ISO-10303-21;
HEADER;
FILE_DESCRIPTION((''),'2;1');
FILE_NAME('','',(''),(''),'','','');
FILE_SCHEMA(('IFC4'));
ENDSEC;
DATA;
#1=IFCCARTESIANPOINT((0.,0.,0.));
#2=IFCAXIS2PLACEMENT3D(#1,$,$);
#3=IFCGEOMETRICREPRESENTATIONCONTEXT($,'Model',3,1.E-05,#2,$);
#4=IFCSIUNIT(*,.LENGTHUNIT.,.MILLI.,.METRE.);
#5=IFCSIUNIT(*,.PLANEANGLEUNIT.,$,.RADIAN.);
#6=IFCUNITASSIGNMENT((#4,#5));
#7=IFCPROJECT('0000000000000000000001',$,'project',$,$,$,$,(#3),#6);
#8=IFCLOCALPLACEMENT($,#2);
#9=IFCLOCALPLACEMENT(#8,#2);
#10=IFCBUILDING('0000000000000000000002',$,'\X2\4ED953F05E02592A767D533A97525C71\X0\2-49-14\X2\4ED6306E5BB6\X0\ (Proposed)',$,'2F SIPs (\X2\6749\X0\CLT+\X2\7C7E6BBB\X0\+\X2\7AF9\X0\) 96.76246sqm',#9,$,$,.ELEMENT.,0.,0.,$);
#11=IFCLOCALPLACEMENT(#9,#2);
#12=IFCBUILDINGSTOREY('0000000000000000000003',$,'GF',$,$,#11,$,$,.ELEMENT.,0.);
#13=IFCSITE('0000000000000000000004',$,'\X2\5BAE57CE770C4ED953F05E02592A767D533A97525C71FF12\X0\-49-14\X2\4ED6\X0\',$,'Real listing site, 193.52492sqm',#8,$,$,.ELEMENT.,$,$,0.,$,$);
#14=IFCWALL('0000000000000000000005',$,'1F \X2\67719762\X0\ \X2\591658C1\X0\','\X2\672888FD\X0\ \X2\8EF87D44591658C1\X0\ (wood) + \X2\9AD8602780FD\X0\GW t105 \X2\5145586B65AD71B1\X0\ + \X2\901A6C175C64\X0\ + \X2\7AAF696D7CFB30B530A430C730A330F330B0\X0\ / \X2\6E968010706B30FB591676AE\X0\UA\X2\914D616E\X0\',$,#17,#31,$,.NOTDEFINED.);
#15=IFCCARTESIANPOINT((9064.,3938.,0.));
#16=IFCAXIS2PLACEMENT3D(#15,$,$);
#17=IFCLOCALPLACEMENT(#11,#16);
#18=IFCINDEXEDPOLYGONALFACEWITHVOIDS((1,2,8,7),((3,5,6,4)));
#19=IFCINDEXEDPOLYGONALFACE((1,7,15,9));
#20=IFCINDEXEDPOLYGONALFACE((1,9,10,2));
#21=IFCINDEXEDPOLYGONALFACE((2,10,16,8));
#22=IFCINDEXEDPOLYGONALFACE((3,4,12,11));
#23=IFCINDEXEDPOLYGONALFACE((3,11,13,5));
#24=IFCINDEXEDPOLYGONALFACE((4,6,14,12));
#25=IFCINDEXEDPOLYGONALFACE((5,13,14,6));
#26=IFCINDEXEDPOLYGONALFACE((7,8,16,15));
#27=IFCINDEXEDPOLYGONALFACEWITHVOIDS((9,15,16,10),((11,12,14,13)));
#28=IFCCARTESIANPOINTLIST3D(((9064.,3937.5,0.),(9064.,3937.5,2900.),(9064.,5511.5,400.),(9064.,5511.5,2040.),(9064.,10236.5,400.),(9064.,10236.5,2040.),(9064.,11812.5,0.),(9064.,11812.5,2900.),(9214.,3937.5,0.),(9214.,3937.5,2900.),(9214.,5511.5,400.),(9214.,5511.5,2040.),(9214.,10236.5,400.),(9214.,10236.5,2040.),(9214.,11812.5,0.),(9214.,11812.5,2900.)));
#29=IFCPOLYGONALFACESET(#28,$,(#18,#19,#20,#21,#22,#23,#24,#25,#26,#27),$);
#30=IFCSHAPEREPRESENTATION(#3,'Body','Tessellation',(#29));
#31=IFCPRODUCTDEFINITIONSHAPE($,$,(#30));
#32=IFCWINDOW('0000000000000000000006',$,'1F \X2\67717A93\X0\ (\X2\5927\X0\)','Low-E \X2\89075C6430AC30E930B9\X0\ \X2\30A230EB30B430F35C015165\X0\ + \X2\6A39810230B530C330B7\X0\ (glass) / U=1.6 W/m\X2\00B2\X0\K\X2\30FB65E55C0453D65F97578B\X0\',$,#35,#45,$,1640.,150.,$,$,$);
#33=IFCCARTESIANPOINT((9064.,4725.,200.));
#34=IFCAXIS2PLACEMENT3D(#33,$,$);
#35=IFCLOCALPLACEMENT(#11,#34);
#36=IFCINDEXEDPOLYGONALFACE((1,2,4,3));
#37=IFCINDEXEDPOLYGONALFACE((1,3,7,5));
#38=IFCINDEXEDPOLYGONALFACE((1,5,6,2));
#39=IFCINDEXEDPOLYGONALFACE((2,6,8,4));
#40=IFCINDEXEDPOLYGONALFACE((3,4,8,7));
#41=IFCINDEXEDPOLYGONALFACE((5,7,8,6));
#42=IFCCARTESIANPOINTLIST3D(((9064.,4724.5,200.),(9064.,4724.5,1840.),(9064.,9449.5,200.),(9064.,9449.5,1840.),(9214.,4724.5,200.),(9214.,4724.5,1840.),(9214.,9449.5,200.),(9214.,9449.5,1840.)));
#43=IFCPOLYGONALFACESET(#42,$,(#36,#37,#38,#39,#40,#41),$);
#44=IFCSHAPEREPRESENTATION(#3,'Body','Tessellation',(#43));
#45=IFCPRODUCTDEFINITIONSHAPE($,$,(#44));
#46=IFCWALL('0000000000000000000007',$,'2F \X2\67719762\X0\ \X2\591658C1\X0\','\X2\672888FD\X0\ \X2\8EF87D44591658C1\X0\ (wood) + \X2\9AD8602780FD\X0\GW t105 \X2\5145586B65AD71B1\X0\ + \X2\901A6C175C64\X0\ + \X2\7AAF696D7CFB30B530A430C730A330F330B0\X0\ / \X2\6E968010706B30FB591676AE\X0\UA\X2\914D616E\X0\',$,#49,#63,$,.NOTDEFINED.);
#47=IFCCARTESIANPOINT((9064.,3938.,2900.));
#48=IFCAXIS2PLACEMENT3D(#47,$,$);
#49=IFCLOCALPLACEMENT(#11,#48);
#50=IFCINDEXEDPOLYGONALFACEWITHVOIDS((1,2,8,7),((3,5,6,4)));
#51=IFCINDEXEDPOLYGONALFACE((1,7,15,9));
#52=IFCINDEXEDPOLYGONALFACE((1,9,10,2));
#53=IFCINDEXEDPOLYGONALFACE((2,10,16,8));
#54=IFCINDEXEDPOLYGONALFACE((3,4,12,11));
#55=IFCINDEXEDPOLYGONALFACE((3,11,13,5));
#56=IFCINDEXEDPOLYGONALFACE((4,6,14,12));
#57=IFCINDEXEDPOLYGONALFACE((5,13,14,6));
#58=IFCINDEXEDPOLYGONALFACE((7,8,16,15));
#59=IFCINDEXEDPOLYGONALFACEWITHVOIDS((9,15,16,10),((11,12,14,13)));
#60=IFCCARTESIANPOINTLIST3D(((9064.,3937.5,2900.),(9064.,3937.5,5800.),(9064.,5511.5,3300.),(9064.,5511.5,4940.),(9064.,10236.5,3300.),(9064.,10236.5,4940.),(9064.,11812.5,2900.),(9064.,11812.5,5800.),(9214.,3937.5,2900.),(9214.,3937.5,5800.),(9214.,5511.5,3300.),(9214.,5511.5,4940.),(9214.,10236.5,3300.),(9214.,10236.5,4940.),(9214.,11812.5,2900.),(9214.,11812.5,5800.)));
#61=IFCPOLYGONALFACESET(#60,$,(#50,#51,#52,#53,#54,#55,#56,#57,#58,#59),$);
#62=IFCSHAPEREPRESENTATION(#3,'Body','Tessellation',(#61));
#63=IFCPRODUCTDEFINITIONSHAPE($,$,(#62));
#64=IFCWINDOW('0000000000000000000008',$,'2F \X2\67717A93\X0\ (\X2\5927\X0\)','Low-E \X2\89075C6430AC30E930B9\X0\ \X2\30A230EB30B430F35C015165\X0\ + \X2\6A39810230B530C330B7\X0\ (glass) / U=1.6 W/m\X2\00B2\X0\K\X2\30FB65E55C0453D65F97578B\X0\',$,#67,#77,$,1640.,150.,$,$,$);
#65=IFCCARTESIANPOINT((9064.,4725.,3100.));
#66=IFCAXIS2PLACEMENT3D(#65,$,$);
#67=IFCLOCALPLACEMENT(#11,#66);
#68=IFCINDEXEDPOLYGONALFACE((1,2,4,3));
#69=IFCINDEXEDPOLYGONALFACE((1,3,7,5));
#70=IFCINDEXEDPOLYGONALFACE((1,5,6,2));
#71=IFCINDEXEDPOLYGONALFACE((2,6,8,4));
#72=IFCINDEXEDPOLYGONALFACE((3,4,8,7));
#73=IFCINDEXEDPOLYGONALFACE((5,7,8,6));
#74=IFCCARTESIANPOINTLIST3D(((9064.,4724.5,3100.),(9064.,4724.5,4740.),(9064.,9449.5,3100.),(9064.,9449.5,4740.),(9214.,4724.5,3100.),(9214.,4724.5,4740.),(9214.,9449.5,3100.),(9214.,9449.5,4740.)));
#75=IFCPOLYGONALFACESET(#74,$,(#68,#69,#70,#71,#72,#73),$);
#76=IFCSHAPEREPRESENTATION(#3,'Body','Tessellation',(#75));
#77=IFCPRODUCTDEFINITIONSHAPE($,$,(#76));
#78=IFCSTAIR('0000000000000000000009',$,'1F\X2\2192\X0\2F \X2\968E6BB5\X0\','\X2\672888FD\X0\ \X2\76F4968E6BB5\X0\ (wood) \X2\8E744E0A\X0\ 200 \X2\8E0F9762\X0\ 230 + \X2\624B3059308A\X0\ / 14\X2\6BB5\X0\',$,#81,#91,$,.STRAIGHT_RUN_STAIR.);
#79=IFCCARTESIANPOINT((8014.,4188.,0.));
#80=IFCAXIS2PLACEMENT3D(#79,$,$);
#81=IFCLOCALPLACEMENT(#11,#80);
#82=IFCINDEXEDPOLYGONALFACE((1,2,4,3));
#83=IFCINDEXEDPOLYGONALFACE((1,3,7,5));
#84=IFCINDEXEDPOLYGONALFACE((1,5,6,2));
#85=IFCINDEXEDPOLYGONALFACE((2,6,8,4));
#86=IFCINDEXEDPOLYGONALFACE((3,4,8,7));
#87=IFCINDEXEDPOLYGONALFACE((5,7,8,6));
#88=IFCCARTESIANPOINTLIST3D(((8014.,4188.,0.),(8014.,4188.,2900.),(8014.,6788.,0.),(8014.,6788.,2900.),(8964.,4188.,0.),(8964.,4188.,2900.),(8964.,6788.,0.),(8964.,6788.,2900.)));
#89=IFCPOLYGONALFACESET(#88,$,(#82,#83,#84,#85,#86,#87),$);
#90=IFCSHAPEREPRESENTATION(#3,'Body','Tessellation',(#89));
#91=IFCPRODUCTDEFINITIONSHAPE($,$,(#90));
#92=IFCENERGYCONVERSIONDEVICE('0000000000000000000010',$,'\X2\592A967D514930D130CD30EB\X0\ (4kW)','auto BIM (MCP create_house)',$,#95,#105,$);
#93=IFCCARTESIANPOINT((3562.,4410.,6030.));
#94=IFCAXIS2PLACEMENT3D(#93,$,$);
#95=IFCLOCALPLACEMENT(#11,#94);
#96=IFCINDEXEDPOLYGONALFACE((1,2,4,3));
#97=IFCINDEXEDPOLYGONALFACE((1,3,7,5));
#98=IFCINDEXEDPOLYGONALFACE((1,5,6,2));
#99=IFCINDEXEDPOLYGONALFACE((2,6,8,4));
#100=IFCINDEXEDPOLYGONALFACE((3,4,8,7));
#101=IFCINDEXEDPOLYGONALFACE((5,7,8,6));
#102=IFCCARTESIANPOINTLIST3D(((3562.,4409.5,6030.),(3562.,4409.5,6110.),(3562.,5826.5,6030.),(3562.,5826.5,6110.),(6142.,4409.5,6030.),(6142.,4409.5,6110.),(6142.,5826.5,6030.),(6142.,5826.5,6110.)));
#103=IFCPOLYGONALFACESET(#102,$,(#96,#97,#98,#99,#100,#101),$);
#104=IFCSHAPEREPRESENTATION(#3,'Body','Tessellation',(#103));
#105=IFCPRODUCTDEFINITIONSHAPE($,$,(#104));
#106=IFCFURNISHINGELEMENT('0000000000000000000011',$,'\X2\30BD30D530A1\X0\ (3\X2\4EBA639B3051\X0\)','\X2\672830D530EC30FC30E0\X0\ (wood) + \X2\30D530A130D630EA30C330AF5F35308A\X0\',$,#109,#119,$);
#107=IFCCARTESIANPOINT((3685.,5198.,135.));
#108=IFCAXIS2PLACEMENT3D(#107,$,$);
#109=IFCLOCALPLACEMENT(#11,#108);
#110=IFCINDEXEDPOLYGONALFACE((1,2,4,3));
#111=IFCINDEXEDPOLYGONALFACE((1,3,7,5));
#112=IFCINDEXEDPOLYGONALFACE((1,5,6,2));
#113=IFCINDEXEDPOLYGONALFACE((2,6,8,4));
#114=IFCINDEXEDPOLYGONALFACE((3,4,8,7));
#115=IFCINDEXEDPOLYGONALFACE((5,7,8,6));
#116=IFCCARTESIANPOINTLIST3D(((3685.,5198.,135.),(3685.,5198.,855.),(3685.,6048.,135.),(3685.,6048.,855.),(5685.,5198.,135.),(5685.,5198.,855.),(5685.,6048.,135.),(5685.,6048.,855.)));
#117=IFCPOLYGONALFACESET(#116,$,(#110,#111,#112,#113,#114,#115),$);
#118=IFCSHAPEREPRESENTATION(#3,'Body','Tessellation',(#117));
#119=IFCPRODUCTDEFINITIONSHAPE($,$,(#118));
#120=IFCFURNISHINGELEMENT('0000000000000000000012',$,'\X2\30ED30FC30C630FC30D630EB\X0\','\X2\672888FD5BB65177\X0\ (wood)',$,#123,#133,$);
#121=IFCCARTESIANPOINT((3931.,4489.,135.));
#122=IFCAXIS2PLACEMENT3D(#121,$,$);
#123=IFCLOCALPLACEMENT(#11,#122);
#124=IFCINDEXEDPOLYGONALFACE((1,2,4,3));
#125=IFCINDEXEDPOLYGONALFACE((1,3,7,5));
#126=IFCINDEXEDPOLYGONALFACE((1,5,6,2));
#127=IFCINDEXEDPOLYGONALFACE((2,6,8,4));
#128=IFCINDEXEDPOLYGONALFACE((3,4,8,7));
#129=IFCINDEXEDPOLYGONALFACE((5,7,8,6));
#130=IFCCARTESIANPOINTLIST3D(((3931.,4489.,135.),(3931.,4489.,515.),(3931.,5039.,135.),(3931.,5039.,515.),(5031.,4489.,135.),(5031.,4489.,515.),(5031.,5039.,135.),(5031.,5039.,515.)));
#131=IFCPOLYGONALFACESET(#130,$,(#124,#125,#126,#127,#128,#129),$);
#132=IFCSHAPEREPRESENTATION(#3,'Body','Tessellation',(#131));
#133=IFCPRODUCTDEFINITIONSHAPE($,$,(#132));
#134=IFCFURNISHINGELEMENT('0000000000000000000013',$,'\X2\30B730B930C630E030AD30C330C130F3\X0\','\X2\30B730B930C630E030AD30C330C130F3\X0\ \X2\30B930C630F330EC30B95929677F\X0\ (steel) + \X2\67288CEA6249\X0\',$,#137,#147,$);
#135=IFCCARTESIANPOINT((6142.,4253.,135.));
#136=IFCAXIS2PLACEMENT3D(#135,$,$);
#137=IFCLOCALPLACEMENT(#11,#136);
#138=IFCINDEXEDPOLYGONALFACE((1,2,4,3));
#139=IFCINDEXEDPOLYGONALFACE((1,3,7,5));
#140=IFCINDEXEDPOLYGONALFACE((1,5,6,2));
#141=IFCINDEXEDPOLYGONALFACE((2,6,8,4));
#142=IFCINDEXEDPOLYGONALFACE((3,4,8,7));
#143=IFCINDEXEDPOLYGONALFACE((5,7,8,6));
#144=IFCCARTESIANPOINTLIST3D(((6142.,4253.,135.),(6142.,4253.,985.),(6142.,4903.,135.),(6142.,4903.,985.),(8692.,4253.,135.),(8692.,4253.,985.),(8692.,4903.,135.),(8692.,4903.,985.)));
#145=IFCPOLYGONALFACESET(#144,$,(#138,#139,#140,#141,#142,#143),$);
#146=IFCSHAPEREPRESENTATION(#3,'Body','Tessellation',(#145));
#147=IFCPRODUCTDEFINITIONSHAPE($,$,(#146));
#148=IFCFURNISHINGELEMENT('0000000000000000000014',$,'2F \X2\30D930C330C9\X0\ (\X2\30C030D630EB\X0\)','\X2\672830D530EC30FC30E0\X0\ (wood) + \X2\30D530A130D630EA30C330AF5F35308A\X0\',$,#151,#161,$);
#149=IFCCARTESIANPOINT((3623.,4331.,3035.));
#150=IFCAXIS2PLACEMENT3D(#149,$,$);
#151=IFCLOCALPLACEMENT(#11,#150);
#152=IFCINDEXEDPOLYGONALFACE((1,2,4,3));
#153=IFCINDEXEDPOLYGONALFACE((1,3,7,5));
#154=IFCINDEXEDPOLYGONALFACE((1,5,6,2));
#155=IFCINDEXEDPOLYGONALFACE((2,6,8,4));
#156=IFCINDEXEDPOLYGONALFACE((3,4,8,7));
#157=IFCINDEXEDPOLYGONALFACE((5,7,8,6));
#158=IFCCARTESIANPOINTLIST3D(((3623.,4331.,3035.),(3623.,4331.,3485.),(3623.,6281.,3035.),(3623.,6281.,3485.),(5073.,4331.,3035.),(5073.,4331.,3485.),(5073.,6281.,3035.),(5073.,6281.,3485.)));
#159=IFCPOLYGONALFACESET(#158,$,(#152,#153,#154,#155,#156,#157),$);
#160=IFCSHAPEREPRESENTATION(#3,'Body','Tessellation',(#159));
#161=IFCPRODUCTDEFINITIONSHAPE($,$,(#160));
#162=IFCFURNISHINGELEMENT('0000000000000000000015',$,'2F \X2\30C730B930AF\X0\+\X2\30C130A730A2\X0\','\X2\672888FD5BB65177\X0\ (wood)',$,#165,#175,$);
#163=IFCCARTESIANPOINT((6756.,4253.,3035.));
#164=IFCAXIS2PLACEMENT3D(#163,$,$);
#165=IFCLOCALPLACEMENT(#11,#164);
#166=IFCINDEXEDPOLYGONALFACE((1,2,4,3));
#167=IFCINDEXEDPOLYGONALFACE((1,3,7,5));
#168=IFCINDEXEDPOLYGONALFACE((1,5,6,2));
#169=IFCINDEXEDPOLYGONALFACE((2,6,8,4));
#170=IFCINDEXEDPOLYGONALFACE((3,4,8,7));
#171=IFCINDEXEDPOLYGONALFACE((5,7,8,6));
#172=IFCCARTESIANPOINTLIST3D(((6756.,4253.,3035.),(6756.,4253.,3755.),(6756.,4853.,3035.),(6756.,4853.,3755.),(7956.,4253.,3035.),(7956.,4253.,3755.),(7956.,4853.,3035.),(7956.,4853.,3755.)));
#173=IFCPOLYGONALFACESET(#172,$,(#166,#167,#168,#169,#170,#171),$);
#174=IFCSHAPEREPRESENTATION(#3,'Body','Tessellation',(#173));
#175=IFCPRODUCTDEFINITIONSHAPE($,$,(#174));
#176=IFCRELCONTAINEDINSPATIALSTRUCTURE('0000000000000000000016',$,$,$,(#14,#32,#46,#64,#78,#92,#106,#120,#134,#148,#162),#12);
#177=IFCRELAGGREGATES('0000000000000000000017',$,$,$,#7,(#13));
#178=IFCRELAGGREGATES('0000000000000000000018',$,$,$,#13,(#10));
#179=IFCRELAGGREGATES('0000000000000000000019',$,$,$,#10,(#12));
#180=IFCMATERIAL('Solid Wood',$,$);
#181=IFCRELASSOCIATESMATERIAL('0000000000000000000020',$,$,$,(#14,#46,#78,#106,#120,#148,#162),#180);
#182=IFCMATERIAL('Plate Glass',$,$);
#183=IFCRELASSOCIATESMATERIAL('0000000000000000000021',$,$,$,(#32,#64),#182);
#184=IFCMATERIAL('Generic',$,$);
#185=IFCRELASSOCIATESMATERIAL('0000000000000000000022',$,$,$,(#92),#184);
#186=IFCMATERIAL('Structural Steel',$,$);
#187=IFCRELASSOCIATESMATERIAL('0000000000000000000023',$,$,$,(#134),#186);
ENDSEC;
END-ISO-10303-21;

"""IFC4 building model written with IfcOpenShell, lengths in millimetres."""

from ifc_helpers import new_model, si_unit, frame, frame_2d, origin, place, context, project, spatial, rectangle, extrude, material, element, fill, save


model = new_model("IFC4")

# Units and contexts
model_context = context("Model", 3, precision=1e-05, world=origin())
ifc_project = project(units=[si_unit("LENGTHUNIT", "METRE", prefix="MILLI"), si_unit("PLANEANGLEUNIT", "RADIAN")], contexts=[model_context])

# Site, building, storey
site_placement = place(None, origin())
site = spatial("IfcSite", under=ifc_project, at=site_placement, Name="宮城県仙台市太白区青山２-49-14他", ObjectType="Real listing site, 193.52492sqm", CompositionType="ELEMENT", RefElevation=0.0)
building_placement = place(site_placement, origin())
building = spatial("IfcBuilding", under=site, at=building_placement, Name="仙台市太白区青山2-49-14他の家 (Proposed)", ObjectType="2F SIPs (杉CLT+籾殻+竹) 96.76246sqm", CompositionType="ELEMENT", ElevationOfRefHeight=0.0, ElevationOfTerrain=0.0)
storey_placement = place(building_placement, origin())
storey = spatial("IfcBuildingStorey", under=building, at=storey_placement, Name="GF", CompositionType="ELEMENT", Elevation=0.0)

# Wall, opening, window
ifc_material_1 = material(Name="Solid Wood")
wall_1_placement = place(storey_placement, frame((9064.0, 3938.0, 0.0)))
wall_1 = element("IfcWall", 1, at=wall_1_placement, inside=storey, material=ifc_material_1, Name="1F 東面 外壁", Description="木製 軸組外壁 (wood) + 高性能GW t105 充填断熱 + 通気層 + 窯業系サイディング / 準耐火・外皮UA配慮", PredefinedType="NOTDEFINED", context=model_context, shape_type="SweptSolid", body=[
    extrude(rectangle(XDim=150.0, YDim=7875.0, at=frame_2d((75.0, 3937.0))), frame((9064.0, 3938.0, 0.0)), (0.0, 0.0, 1.0), 2900.0),
])
opening_1_placement = place(storey_placement, frame((9064.0, 4725.0, 200.0)))
opening_1 = element("IfcOpeningElement", 2, at=opening_1_placement, cuts=wall_1, PredefinedType="NOTDEFINED", context=model_context, shape_type="SweptSolid", body=[
    extrude(rectangle(XDim=150.0, YDim=4725.0, at=frame_2d((75.0, 2362.0))), frame((9064.0, 4725.0, 200.0)), (0.0, 0.0, 1.0), 1640.0),
])
ifc_material_2 = material(Name="Plate Glass")
window_1_placement = place(storey_placement, frame((9064.0, 4725.0, 200.0)))
window_1 = element("IfcWindow", 3, at=window_1_placement, inside=storey, material=ifc_material_2, Name="1F 東窓 (大)", Description="Low-E 複層ガラス アルゴン封入 + 樹脂サッシ (glass) / U=1.6 W/m²K・日射取得型", OverallHeight=1640.0, OverallWidth=150.0, context=model_context, shape_type="SweptSolid", body=[
    extrude(rectangle(XDim=150.0, YDim=4725.0, at=frame_2d((75.0, 2362.0))), frame((9064.0, 4725.0, 200.0)), (0.0, 0.0, 1.0), 1640.0),
])
fill(opening_1, window_1)

# Wall, opening, window
wall_2_placement = place(storey_placement, frame((9064.0, 3938.0, 2900.0)))
wall_2 = element("IfcWall", 4, at=wall_2_placement, inside=storey, material=ifc_material_1, Name="2F 東面 外壁", Description="木製 軸組外壁 (wood) + 高性能GW t105 充填断熱 + 通気層 + 窯業系サイディング / 準耐火・外皮UA配慮", PredefinedType="NOTDEFINED", context=model_context, shape_type="SweptSolid", body=[
    extrude(rectangle(XDim=150.0, YDim=7875.0, at=frame_2d((75.0, 3937.0))), frame((9064.0, 3938.0, 2900.0)), (0.0, 0.0, 1.0), 2900.0),
])
opening_2_placement = place(storey_placement, frame((9064.0, 4725.0, 3100.0)))
opening_2 = element("IfcOpeningElement", 5, at=opening_2_placement, cuts=wall_2, PredefinedType="NOTDEFINED", context=model_context, shape_type="SweptSolid", body=[
    extrude(rectangle(XDim=150.0, YDim=4725.0, at=frame_2d((75.0, 2362.0))), frame((9064.0, 4725.0, 3100.0)), (0.0, 0.0, 1.0), 1640.0),
])
window_2_placement = place(storey_placement, frame((9064.0, 4725.0, 3100.0)))
window_2 = element("IfcWindow", 6, at=window_2_placement, inside=storey, material=ifc_material_2, Name="2F 東窓 (大)", Description="Low-E 複層ガラス アルゴン封入 + 樹脂サッシ (glass) / U=1.6 W/m²K・日射取得型", OverallHeight=1640.0, OverallWidth=150.0, context=model_context, shape_type="SweptSolid", body=[
    extrude(rectangle(XDim=150.0, YDim=4725.0, at=frame_2d((75.0, 2362.0))), frame((9064.0, 4725.0, 3100.0)), (0.0, 0.0, 1.0), 1640.0),
])
fill(opening_2, window_2)

# Stair
stair_placement = place(storey_placement, frame((8014.0, 4188.0, 0.0)))
element("IfcStair", 7, at=stair_placement, inside=storey, material=ifc_material_1, Name="1F→2F 階段", Description="木製 直階段 (wood) 蹴上 200 踏面 230 + 手すり / 14段", PredefinedType="STRAIGHT_RUN_STAIR", context=model_context, shape_type="SweptSolid", body=[
    extrude(rectangle(XDim=950.0, YDim=2600.0, at=frame_2d((475.0, 1300.0))), frame((8014.0, 4188.0, 0.0)), (0.0, 0.0, 1.0), 2900.0),
])

# Energy conversion device
ifc_material_3 = material(Name="Generic")
energy_conversion_device_placement = place(storey_placement, frame((3562.0, 4410.0, 6030.0)))
element("IfcEnergyConversionDevice", 8, at=energy_conversion_device_placement, inside=storey, material=ifc_material_3, Name="太陽光パネル (4kW)", Description="auto BIM (MCP create_house)", context=model_context, shape_type="SweptSolid", body=[
    extrude(rectangle(XDim=2580.0, YDim=1417.0, at=frame_2d((1290.0, 708.0))), frame((3562.0, 4410.0, 6030.0)), (0.0, 0.0, 1.0), 80.0),
])

# Furnishing elements
furnishing_1_placement = place(storey_placement, frame((3685.0, 5198.0, 135.0)))
element("IfcFurnishingElement", 9, at=furnishing_1_placement, inside=storey, material=ifc_material_1, Name="ソファ (3人掛け)", Description="木フレーム (wood) + ファブリック張り", context=model_context, shape_type="SweptSolid", body=[
    extrude(rectangle(XDim=2000.0, YDim=850.0, at=frame_2d((1000.0, 425.0))), frame((3685.0, 5198.0, 135.0)), (0.0, 0.0, 1.0), 720.0),
])
furnishing_2_placement = place(storey_placement, frame((3931.0, 4489.0, 135.0)))
element("IfcFurnishingElement", 10, at=furnishing_2_placement, inside=storey, material=ifc_material_1, Name="ローテーブル", Description="木製家具 (wood)", context=model_context, shape_type="SweptSolid", body=[
    extrude(rectangle(XDim=1100.0, YDim=550.0, at=frame_2d((550.0, 275.0))), frame((3931.0, 4489.0, 135.0)), (0.0, 0.0, 1.0), 380.0),
])
ifc_material_4 = material(Name="Structural Steel")
furnishing_3_placement = place(storey_placement, frame((6142.0, 4253.0, 135.0)))
element("IfcFurnishingElement", 11, at=furnishing_3_placement, inside=storey, material=ifc_material_4, Name="システムキッチン", Description="システムキッチン ステンレス天板 (steel) + 木質扉", context=model_context, shape_type="SweptSolid", body=[
    extrude(rectangle(XDim=2550.0, YDim=650.0, at=frame_2d((1275.0, 325.0))), frame((6142.0, 4253.0, 135.0)), (0.0, 0.0, 1.0), 850.0),
])
furnishing_4_placement = place(storey_placement, frame((3623.0, 4331.0, 3035.0)))
element("IfcFurnishingElement", 12, at=furnishing_4_placement, inside=storey, material=ifc_material_1, Name="2F ベッド (ダブル)", Description="木フレーム (wood) + ファブリック張り", context=model_context, shape_type="SweptSolid", body=[
    extrude(rectangle(XDim=1450.0, YDim=1950.0, at=frame_2d((725.0, 975.0))), frame((3623.0, 4331.0, 3035.0)), (0.0, 0.0, 1.0), 450.0),
])
furnishing_5_placement = place(storey_placement, frame((6756.0, 4253.0, 3035.0)))
element("IfcFurnishingElement", 13, at=furnishing_5_placement, inside=storey, material=ifc_material_1, Name="2F デスク+チェア", Description="木製家具 (wood)", context=model_context, shape_type="SweptSolid", body=[
    extrude(rectangle(XDim=1200.0, YDim=600.0, at=frame_2d((600.0, 300.0))), frame((6756.0, 4253.0, 3035.0)), (0.0, 0.0, 1.0), 720.0),
])

save(model, "model.ifc")
